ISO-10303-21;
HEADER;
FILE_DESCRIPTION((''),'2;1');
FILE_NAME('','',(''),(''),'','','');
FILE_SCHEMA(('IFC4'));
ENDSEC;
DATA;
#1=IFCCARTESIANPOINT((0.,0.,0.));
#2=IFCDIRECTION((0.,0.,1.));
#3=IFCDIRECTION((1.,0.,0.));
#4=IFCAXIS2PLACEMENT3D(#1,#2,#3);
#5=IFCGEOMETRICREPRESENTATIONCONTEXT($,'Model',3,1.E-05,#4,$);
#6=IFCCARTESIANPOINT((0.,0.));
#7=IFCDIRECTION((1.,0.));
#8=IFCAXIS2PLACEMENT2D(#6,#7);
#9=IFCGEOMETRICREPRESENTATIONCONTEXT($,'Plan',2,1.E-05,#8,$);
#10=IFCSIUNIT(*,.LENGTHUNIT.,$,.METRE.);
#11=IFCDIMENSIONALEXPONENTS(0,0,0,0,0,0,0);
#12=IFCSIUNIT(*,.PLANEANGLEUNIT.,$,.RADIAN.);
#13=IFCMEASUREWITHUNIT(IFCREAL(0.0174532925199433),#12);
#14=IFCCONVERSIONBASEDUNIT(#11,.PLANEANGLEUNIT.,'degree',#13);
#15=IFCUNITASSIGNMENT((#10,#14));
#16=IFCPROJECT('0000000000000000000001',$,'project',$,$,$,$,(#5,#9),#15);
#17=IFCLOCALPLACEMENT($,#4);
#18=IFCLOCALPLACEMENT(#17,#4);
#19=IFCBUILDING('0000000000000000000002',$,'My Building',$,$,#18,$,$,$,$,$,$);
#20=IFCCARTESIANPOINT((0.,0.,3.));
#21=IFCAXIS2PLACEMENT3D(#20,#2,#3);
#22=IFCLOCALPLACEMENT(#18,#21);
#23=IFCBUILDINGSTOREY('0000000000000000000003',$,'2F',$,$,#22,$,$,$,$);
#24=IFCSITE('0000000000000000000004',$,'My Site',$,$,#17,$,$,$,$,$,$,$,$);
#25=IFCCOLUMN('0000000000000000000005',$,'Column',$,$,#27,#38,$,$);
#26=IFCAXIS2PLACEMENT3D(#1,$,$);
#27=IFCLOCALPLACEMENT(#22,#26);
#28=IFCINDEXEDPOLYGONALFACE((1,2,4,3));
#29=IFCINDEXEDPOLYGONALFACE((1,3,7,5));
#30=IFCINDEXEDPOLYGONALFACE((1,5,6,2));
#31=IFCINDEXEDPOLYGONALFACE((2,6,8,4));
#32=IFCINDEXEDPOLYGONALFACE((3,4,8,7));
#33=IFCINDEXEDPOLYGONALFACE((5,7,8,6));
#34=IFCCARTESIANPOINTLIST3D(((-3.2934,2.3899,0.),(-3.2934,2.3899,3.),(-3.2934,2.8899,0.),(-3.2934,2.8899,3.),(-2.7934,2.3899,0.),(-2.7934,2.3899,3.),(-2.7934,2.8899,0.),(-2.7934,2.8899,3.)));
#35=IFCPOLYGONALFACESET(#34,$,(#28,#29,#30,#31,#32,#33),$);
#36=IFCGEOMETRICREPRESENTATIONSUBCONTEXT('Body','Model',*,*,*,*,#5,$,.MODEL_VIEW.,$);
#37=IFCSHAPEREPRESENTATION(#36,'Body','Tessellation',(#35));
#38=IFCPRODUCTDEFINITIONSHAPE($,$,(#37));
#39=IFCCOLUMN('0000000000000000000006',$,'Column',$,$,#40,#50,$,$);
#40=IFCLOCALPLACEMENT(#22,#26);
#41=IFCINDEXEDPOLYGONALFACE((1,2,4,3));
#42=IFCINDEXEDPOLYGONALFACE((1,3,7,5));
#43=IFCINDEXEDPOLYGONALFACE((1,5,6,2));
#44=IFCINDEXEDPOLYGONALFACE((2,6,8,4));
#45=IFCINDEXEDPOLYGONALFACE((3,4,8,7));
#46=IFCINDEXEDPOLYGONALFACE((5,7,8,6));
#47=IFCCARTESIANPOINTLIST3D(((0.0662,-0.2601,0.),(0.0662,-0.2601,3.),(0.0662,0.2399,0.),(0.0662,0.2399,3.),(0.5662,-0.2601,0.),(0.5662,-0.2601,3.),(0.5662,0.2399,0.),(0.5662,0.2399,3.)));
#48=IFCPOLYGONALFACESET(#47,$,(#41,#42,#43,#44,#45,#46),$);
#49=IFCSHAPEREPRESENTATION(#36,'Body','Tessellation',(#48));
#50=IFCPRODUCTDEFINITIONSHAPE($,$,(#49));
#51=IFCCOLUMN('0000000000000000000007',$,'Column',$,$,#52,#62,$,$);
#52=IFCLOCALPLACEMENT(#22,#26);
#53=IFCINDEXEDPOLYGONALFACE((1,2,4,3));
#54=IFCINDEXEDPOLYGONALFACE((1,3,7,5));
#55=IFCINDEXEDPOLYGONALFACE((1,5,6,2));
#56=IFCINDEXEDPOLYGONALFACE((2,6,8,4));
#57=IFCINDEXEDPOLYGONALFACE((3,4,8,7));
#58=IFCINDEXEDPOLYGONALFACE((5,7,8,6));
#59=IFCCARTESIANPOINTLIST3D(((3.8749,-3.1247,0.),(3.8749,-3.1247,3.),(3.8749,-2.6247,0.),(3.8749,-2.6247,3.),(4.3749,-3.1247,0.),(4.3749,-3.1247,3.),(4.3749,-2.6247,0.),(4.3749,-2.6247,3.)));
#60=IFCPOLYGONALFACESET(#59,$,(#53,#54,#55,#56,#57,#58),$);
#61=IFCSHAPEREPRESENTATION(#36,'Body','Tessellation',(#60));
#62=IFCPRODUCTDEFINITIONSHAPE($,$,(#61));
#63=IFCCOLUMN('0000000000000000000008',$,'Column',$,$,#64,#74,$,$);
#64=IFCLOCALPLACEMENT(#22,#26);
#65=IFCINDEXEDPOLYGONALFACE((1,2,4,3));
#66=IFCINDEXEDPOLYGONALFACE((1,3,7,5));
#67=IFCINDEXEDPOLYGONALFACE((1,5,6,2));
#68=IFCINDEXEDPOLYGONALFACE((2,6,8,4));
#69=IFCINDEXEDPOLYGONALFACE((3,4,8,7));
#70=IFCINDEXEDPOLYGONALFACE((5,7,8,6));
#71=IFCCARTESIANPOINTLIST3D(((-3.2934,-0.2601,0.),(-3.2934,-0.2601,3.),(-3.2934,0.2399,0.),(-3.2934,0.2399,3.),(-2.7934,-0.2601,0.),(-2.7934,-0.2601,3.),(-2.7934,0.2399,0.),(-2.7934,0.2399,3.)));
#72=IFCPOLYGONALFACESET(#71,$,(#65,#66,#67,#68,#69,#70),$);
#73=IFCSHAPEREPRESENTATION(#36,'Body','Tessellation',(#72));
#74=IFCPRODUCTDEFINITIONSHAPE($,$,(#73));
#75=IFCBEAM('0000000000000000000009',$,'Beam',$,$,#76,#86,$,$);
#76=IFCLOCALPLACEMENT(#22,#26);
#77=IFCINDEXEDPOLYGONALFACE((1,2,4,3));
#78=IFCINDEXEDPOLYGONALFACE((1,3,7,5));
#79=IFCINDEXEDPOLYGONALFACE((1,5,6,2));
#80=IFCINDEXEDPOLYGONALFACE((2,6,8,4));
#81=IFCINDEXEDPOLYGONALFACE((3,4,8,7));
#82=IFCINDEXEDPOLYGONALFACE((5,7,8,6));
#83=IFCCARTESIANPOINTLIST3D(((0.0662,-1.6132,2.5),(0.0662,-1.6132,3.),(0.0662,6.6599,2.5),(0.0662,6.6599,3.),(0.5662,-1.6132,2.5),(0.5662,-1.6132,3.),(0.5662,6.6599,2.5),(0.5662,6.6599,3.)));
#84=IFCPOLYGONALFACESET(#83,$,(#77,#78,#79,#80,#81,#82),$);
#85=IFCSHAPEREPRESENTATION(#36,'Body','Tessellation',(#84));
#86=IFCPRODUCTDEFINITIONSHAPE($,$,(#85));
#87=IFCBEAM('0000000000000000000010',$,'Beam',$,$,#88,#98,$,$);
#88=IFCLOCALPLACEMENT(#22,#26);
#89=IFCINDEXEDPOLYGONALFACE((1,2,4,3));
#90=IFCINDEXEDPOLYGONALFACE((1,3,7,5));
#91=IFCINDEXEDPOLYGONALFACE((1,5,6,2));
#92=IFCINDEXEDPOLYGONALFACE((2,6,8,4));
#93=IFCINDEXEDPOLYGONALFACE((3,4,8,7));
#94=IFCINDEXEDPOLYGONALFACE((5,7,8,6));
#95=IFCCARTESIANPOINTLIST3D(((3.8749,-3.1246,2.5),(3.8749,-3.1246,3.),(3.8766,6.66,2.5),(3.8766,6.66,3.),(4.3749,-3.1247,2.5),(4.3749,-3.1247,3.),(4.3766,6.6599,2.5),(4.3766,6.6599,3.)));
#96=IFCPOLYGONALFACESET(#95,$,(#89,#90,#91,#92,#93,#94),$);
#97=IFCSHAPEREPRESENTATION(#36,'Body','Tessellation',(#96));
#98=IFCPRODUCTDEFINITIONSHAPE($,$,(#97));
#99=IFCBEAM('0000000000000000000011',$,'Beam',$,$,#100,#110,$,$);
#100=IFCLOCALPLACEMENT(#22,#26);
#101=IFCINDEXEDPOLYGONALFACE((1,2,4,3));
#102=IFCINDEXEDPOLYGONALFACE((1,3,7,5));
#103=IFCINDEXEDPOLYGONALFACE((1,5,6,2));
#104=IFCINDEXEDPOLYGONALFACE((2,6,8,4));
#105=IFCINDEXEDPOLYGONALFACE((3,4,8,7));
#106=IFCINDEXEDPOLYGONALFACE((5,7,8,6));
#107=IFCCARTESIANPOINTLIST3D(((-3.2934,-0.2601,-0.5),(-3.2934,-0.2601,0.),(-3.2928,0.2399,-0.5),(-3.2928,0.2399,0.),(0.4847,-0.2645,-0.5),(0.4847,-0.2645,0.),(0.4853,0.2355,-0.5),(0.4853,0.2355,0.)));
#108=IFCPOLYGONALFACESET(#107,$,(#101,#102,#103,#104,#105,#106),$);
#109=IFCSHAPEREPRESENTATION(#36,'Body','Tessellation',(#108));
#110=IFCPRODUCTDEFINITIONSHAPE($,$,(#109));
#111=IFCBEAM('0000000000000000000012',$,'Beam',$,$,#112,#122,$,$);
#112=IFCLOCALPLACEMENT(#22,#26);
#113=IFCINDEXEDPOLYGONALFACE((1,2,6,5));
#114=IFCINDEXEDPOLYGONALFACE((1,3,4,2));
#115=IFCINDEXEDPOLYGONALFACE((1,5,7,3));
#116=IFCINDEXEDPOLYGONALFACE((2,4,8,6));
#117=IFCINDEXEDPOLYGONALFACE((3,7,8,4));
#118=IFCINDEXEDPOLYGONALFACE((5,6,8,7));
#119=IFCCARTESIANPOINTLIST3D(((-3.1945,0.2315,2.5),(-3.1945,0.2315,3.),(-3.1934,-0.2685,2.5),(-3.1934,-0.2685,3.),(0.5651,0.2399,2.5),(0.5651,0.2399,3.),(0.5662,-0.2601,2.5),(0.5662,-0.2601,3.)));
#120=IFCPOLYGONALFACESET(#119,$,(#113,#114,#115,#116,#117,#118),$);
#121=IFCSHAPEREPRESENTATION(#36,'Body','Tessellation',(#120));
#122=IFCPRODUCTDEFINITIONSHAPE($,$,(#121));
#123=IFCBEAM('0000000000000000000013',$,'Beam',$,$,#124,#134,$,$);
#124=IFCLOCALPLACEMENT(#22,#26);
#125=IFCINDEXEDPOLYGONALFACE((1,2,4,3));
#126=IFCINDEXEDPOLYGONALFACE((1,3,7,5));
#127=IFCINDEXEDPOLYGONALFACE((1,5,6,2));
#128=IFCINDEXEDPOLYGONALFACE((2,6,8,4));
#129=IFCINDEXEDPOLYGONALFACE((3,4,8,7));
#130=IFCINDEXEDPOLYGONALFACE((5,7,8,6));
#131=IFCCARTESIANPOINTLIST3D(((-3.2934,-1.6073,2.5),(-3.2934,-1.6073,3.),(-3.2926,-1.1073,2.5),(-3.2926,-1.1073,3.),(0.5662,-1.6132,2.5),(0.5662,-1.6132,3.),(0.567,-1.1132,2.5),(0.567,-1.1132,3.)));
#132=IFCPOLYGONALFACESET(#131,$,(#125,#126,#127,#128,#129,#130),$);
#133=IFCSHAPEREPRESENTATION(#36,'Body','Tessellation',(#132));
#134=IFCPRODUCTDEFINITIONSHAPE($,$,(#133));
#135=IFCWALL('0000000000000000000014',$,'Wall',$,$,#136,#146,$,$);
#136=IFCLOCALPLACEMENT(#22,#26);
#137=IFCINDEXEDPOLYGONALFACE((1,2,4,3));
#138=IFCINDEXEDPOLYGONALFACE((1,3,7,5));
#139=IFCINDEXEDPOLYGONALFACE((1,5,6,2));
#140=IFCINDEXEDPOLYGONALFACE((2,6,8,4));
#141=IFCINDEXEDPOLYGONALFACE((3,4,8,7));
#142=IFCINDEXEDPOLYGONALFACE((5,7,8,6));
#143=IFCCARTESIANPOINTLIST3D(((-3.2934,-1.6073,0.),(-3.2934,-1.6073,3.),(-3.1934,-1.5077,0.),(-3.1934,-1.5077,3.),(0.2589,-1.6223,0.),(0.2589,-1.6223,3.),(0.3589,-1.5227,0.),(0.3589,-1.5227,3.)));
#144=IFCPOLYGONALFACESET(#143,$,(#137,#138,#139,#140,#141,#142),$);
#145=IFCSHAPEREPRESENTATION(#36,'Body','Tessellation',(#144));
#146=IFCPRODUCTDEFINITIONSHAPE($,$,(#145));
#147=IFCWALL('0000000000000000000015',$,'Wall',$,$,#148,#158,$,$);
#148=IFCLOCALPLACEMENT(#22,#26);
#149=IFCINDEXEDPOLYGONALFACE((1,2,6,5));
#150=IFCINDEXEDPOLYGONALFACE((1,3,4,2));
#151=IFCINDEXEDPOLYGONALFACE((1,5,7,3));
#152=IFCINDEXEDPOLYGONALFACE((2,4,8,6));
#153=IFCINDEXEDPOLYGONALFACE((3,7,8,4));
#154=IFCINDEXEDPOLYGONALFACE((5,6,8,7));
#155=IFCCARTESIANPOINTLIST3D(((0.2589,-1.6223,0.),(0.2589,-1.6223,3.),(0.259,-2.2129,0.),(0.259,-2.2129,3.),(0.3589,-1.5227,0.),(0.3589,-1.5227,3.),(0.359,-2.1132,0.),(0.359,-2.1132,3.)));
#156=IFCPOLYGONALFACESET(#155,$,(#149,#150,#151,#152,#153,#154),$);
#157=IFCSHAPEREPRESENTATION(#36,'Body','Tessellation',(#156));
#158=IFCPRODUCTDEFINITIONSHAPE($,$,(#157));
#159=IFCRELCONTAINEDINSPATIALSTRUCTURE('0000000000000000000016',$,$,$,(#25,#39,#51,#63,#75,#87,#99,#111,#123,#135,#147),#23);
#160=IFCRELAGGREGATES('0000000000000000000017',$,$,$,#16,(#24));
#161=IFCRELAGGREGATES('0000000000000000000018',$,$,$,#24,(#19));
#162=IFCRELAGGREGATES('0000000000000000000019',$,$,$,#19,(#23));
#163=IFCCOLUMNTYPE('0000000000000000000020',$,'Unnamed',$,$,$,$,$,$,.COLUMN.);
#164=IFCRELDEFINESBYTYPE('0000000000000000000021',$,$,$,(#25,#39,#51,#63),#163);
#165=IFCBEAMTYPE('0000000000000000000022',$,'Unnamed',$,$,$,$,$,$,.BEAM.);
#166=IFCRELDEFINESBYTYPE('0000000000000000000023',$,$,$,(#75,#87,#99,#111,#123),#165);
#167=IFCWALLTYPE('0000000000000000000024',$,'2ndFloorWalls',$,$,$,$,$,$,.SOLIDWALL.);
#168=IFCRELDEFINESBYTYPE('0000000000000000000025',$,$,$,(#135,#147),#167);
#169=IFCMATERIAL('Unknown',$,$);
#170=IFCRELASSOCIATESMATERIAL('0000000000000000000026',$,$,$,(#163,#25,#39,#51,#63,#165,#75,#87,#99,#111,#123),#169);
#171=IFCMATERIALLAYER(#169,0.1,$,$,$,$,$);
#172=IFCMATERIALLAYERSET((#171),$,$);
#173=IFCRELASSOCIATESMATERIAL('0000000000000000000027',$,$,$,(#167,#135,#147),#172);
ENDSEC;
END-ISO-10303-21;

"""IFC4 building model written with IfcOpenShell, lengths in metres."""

from ifc_helpers import new_model, entity, si_unit, converted_unit, frame, origin_with_axes, origin_2d_with_axis, place, context, subcontext, project, spatial, line, indexed_curve, rectangle, outline, extrude, material, layer, layer_set, layer_usage, material_profile, profile_set, profile_usage, type_object, element, save


model = new_model("IFC4")

# Units and contexts
model_context = context("Model", 3, precision=1e-05, world=origin_with_axes())
plan_context = context("Plan", 2, precision=1e-05, world=origin_2d_with_axis())
body_context_1 = subcontext(model_context, "Body", "Model", "MODEL_VIEW")
ifc_project = project(units=[si_unit("LENGTHUNIT", "METRE"), converted_unit("PLANEANGLEUNIT", "degree", entity("IfcReal", 0.0174532925199433), si_unit("PLANEANGLEUNIT", "RADIAN"), dimensions=[0, 0, 0, 0, 0, 0, 0])], contexts=[model_context, plan_context])

# Site, building, storey
site_placement = place(None, origin_with_axes())
site = spatial("IfcSite", under=ifc_project, at=site_placement, Name="My Site")
building_placement = place(site_placement, origin_with_axes())
building = spatial("IfcBuilding", under=site, at=building_placement, Name="My Building")
storey_placement = place(building_placement, frame((0.0, 0.0, 3.0), z_axis=(0.0, 0.0, 1.0), x_axis=(1.0, 0.0, 0.0)))
storey = spatial("IfcBuildingStorey", under=building, at=storey_placement, Name="2F")

# Columns
ifc_material = material(Name="Unknown")
ifc_material_profile_1 = material_profile(ifc_material, rectangle(XDim=0.5, YDim=0.5))
ifc_profile_set_1 = profile_set([ifc_material_profile_1])
ifc_profile_usage_1 = profile_usage(ifc_profile_set_1, cardinal=3)
column_type = type_object("IfcColumnType", Name="Unnamed", PredefinedType="COLUMN", material=ifc_profile_set_1)
column_1_placement = place(storey_placement, frame((-3.2934, 2.3899, 0.0), z_axis=(0.0, 0.0, 1.0), x_axis=(1.0, 0.0, 0.0)))
element("IfcColumn", 1, at=column_1_placement, inside=storey, type_object=column_type, material=ifc_profile_usage_1, Name="Column", context=body_context_1, shape_type="SweptSolid", body=[
    extrude(rectangle(XDim=0.5, YDim=0.5), frame((0.25, 0.25, 0.0), z_axis=(0.0, 0.0, 1.0), x_axis=(1.0, 0.0, 0.0)), (0.0, 0.0, 1.0), 3.0),
])
ifc_profile_usage_2 = profile_usage(ifc_profile_set_1, cardinal=7)
column_2_placement = place(storey_placement, frame((0.5662, 0.2399, 0.0), z_axis=(0.0, 0.0, 1.0), x_axis=(1.0, 0.0, 0.0)))
element("IfcColumn", 2, at=column_2_placement, inside=storey, type_object=column_type, material=ifc_profile_usage_2, Name="Column", context=body_context_1, shape_type="SweptSolid", body=[
    extrude(rectangle(XDim=0.5, YDim=0.5), frame((-0.25, -0.25, 0.0), z_axis=(0.0, 0.0, 1.0), x_axis=(1.0, 0.0, 0.0)), (0.0, 0.0, 1.0), 3.0),
])
ifc_profile_usage_3 = profile_usage(ifc_profile_set_1, cardinal=7)
column_3_placement = place(storey_placement, frame((4.3749, -2.6247, 0.0), z_axis=(0.0, 0.0, 1.0), x_axis=(1.0, 0.0, 0.0)))
element("IfcColumn", 3, at=column_3_placement, inside=storey, type_object=column_type, material=ifc_profile_usage_3, Name="Column", context=body_context_1, shape_type="SweptSolid", body=[
    extrude(rectangle(XDim=0.5, YDim=0.5), frame((-0.25, -0.25, 0.0), z_axis=(0.0, 0.0, 1.0), x_axis=(1.0, 0.0, 0.0)), (0.0, 0.0, 1.0), 3.0),
])
ifc_profile_usage_4 = profile_usage(ifc_profile_set_1, cardinal=9)
column_4_placement = place(storey_placement, frame((-3.2934, 0.2399, 0.0), z_axis=(0.0, 0.0, 1.0), x_axis=(1.0, 0.0, 0.0)))
element("IfcColumn", 4, at=column_4_placement, inside=storey, type_object=column_type, material=ifc_profile_usage_4, Name="Column", context=body_context_1, shape_type="SweptSolid", body=[
    extrude(rectangle(XDim=0.5, YDim=0.5), frame((0.25, -0.25, 0.0), z_axis=(0.0, 0.0, 1.0), x_axis=(1.0, 0.0, 0.0)), (0.0, 0.0, 1.0), 3.0),
])

# Beams
ifc_material_profile_2 = material_profile(ifc_material, rectangle(XDim=0.5, YDim=0.5))
ifc_profile_set_2 = profile_set([ifc_material_profile_2])
ifc_profile_usage_5 = profile_usage(ifc_profile_set_2, cardinal=9)
beam_type = type_object("IfcBeamType", Name="Unnamed", PredefinedType="BEAM", material=ifc_profile_set_2)
beam_1_placement = place(storey_placement, frame((0.5662, -1.6132, 3.0), z_axis=(0.0, 1.0, 0.0), x_axis=(-1.0, 0.0, 0.0)))
element("IfcBeam", 5, at=beam_1_placement, inside=storey, type_object=beam_type, material=ifc_profile_usage_5, Name="Beam", context=body_context_1, shape_type="SweptSolid", body=[
    extrude(rectangle(XDim=0.5, YDim=0.5), frame((0.25, -0.25, 0.0), z_axis=(0.0, 0.0, 1.0), x_axis=(1.0, 0.0, 0.0)), (0.0, 0.0, 1.0), 8.2731),
])
ifc_profile_usage_6 = profile_usage(ifc_profile_set_2, cardinal=9)
beam_2_placement = place(storey_placement, frame((4.3749, -3.1247, 3.0), z_axis=(0.000173, 1.0, 0.0), x_axis=(-1.0, 0.000173, 0.0)))
element("IfcBeam", 6, at=beam_2_placement, inside=storey, type_object=beam_type, material=ifc_profile_usage_6, Name="Beam", context=body_context_1, shape_type="SweptSolid", body=[
    extrude(rectangle(XDim=0.5, YDim=0.5), frame((0.25, -0.25, 0.0), z_axis=(0.0, 0.0, 1.0), x_axis=(1.0, 0.0, 0.0)), (0.0, 0.0, 1.0), 9.7846),
])
ifc_profile_usage_7 = profile_usage(ifc_profile_set_2, cardinal=9)
beam_3_placement = place(storey_placement, frame((-3.2934, -0.2601, 0.0), z_axis=(0.999999, -0.001172, 0.0), x_axis=(0.001172, 0.999999, 0.0)))
element("IfcBeam", 7, at=beam_3_placement, inside=storey, type_object=beam_type, material=ifc_profile_usage_7, Name="Beam", context=body_context_1, shape_type="SweptSolid", body=[
    extrude(rectangle(XDim=0.5, YDim=0.5), frame((0.25, -0.25, 0.0), z_axis=(0.0, 0.0, 1.0), x_axis=(1.0, 0.0, 0.0)), (0.0, 0.0, 1.0), 3.7781),
])
ifc_profile_usage_8 = profile_usage(ifc_profile_set_2, cardinal=7)
beam_4_placement = place(storey_placement, frame((0.5662, -0.2601, 3.0), z_axis=(-0.999998, -0.002223, 0.0), x_axis=(0.002223, -0.999998, 0.0)))
element("IfcBeam", 8, at=beam_4_placement, inside=storey, type_object=beam_type, material=ifc_profile_usage_8, Name="Beam", context=body_context_1, shape_type="SweptSolid", body=[
    extrude(rectangle(XDim=0.5, YDim=0.5), frame((-0.25, -0.25, 0.0), z_axis=(0.0, 0.0, 1.0), x_axis=(1.0, 0.0, 0.0)), (0.0, 0.0, 1.0), 3.7596),
])
ifc_profile_usage_9 = profile_usage(ifc_profile_set_2, cardinal=7)
beam_5_placement = place(storey_placement, frame((0.5662, -1.6132, 3.0), z_axis=(-0.999999, 0.001519, 0.0), x_axis=(-0.001519, -0.999999, 0.0)))
element("IfcBeam", 9, at=beam_5_placement, inside=storey, type_object=beam_type, material=ifc_profile_usage_9, Name="Beam", context=body_context_1, shape_type="SweptSolid", body=[
    extrude(rectangle(XDim=0.5, YDim=0.5), frame((-0.25, -0.25, 0.0), z_axis=(0.0, 0.0, 1.0), x_axis=(1.0, 0.0, 0.0)), (0.0, 0.0, 1.0), 3.8596),
])

# Walls
ifc_layer = layer(ifc_material, 0.1)
ifc_layer_set = layer_set([ifc_layer])
ifc_layer_usage_1 = layer_usage(ifc_layer_set, "AXIS2", "POSITIVE", 0.0)
wall_type = type_object("IfcWallType", Name="2ndFloorWalls", PredefinedType="SOLIDWALL", material=ifc_layer_set)
wall_1_placement = place(storey_placement, frame((-3.2934, -1.6073, 0.0), z_axis=(0.0, 0.0, 1.0), x_axis=(0.999991, -0.004229, 0.0)))
element("IfcWall", 10, at=wall_1_placement, inside=storey, type_object=wall_type, material=ifc_layer_usage_1, Name="Wall", context=body_context_1, shape_type="SweptSolid", body=[
    extrude(outline(indexed_curve([(0.0, 0.0), (0.0996, 0.1), (3.6519, 0.1), (3.5523, 0.0)], segments=[line(1, 2, 3, 4, 1)])), origin_with_axes(), (0.0, 0.0, 1.0), 3.0),
])
ifc_layer_usage_2 = layer_usage(ifc_layer_set, "AXIS2", "POSITIVE", 0.0)
wall_2_placement = place(storey_placement, frame((0.2589, -1.6223, 0.0), z_axis=(0.0, 0.0, 1.0), x_axis=(0.000177, -1.0, 0.0)))
element("IfcWall", 11, at=wall_2_placement, inside=storey, type_object=wall_type, material=ifc_layer_usage_2, Name="Wall", context=body_context_1, shape_type="SweptSolid", body=[
    extrude(outline(indexed_curve([(0.0, 0.0), (-0.0996, 0.1), (0.4909, 0.1), (0.5905, 0.0)], segments=[line(1, 2, 3, 4, 1)])), origin_with_axes(), (0.0, 0.0, 1.0), 3.0),
])

save(model, "model.ifc")
